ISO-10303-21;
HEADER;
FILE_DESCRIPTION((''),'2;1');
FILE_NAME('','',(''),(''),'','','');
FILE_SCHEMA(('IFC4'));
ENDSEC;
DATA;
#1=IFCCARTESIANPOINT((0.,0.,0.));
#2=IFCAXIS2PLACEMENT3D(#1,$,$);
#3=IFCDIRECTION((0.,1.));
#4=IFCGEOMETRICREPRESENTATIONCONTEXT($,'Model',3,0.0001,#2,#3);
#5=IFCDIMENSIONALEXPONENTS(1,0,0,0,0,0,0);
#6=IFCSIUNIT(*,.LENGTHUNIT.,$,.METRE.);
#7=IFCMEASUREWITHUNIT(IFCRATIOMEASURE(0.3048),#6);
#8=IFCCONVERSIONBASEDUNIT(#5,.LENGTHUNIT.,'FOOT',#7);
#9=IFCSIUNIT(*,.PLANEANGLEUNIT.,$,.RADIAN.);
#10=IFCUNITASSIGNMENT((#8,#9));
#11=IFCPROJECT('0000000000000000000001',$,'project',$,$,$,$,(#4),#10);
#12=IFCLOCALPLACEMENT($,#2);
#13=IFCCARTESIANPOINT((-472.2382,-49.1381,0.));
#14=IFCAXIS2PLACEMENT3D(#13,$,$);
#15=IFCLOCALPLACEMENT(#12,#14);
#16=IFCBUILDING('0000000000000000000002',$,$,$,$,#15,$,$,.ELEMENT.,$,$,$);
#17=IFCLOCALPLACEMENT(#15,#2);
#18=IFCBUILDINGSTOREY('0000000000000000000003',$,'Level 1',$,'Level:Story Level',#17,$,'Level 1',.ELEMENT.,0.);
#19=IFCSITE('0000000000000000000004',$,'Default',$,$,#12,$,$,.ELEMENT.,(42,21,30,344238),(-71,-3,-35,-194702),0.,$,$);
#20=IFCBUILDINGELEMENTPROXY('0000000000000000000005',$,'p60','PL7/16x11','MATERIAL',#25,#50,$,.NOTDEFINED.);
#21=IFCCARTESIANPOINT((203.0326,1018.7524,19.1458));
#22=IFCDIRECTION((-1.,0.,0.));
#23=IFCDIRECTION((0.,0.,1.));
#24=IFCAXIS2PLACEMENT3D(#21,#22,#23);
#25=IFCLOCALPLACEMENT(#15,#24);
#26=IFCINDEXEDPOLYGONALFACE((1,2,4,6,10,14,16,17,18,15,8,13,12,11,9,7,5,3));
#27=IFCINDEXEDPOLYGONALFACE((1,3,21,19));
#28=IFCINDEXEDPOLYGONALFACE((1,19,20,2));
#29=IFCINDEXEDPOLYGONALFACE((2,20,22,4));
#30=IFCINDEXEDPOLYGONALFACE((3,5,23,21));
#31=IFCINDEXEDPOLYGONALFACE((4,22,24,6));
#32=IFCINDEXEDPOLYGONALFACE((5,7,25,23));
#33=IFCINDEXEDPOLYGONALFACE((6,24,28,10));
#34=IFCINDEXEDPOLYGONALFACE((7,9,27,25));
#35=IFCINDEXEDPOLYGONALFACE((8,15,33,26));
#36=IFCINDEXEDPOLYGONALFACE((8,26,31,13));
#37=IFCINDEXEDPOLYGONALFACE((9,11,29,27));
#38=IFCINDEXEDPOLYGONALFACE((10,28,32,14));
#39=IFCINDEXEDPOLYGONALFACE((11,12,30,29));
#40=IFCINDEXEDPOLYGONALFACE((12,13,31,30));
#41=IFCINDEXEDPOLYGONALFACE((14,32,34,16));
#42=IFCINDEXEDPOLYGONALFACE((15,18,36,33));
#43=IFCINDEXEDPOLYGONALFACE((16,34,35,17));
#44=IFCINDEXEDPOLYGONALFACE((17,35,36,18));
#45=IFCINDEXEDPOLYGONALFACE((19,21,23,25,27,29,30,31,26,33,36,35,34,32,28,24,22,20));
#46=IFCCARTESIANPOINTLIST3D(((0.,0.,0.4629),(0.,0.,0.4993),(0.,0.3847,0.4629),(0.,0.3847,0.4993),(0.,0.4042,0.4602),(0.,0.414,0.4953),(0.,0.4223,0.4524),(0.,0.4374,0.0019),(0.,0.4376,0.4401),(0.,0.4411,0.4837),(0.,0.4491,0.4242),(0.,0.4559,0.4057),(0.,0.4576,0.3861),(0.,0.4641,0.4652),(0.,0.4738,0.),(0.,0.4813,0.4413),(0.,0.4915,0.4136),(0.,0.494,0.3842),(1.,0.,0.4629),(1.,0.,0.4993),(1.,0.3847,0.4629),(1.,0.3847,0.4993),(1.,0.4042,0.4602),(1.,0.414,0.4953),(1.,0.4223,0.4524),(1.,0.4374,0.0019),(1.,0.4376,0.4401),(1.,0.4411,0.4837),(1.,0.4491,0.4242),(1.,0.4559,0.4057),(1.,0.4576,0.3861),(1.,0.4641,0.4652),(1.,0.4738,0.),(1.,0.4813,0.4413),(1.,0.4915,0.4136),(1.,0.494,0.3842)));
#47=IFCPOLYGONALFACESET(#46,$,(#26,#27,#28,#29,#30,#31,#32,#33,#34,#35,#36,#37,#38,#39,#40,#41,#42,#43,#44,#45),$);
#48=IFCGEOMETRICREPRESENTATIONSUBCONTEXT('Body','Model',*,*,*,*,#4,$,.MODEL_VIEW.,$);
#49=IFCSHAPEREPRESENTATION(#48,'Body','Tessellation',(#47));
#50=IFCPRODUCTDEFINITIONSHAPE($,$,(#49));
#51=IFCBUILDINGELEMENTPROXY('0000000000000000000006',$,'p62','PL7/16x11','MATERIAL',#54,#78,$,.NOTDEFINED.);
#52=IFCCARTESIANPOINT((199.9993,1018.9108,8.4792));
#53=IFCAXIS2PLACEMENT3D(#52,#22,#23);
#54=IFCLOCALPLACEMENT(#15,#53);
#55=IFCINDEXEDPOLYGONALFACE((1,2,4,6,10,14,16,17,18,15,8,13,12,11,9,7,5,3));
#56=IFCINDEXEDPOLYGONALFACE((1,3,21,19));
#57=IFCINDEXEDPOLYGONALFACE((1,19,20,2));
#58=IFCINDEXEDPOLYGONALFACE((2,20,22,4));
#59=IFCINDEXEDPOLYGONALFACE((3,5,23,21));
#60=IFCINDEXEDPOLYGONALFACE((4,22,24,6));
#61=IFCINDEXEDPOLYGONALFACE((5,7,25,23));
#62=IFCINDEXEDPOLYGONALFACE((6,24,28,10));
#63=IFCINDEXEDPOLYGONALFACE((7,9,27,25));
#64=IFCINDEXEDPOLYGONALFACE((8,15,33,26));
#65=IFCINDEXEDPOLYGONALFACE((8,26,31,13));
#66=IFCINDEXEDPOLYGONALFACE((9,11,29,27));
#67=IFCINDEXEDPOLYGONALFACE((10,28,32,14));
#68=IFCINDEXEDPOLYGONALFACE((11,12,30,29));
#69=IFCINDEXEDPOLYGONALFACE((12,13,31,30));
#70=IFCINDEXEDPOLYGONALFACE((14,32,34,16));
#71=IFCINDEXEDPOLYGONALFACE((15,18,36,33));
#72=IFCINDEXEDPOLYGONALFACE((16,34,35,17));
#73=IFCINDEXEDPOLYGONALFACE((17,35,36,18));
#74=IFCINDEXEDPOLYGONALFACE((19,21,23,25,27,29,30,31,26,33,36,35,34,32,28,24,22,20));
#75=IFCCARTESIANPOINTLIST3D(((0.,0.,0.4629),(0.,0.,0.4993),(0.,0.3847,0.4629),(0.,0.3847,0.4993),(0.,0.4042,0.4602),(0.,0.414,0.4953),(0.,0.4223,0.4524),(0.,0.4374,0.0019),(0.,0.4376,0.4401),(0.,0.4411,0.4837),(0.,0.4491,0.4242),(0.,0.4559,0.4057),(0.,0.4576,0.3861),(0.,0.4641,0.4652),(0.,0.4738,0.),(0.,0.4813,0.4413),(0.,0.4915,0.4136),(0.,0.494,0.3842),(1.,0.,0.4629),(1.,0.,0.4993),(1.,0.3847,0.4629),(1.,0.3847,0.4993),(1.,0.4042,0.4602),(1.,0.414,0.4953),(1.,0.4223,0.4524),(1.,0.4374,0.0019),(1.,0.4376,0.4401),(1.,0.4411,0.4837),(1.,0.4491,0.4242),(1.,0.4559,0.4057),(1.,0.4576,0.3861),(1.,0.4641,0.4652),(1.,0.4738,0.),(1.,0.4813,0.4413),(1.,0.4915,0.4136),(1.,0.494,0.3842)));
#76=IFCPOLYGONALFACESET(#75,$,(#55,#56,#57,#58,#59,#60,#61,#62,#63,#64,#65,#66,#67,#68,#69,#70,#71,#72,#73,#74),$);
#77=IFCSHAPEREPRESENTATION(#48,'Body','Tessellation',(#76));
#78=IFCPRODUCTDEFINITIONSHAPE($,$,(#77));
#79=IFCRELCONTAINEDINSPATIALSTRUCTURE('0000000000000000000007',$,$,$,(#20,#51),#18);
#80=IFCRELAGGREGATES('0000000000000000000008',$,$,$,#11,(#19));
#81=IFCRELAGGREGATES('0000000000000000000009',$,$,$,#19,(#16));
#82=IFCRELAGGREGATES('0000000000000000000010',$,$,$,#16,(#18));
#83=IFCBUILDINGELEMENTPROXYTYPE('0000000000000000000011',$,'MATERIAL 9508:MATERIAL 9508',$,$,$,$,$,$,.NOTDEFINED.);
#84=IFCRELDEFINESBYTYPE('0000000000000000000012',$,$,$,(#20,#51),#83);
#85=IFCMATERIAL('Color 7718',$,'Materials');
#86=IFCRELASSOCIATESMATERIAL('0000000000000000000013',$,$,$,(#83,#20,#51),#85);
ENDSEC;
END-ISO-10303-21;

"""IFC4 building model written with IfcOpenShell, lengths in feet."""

from ifc_helpers import new_model, entity, si_unit, converted_unit, direction, frame, origin, place, context, subcontext, project, spatial, polyline, outline, extrude, source, transform, mapped, material, type_object, type_shapes, element, save


model = new_model("IFC4")

# Units and contexts
model_context = context("Model", 3, precision=0.0001, world=origin(), true_north=direction((0.0, 1.0)))
body_context = subcontext(model_context, "Body", "Model", "MODEL_VIEW")
ifc_project = project(units=[converted_unit("LENGTHUNIT", "FOOT", entity("IfcRatioMeasure", 0.3048), si_unit("LENGTHUNIT", "METRE"), dimensions=[1, 0, 0, 0, 0, 0, 0]), si_unit("PLANEANGLEUNIT", "RADIAN")], contexts=[model_context])

# Site, building, storey
site_placement = place(None, origin())
site = spatial("IfcSite", under=ifc_project, at=site_placement, Name="Default", CompositionType="ELEMENT", RefLatitude=(42, 21, 30, 344238), RefLongitude=(-71, -3, -35, -194702), RefElevation=0.0)
building_placement = place(site_placement, frame((-472.2382, -49.1381, 0.0)))
building = spatial("IfcBuilding", under=site, at=building_placement, CompositionType="ELEMENT")
storey_placement = place(building_placement, origin())
storey = spatial("IfcBuildingStorey", under=building, at=storey_placement, Name="Level 1", ObjectType="Level:Story Level", LongName="Level 1", CompositionType="ELEMENT", Elevation=0.0)

# Building element proxies
ifc_material_1 = material(Name="Color 7718", Category="Materials")
building_element_proxy_type_1 = type_object("IfcBuildingElementProxyType", Name="MATERIAL 9508:MATERIAL 9508", PredefinedType="NOTDEFINED", material=ifc_material_1)
shared_shape_1 = source(origin(), body_context, "Body", "SweptSolid", [
    extrude(outline(polyline([(0.0093, -0.1005), (0.3941, -0.1005), (0.3941, -0.0641), (0.0093, -0.0641), (-0.0101, -0.0614), (-0.0282, -0.0536), (-0.0436, -0.0413), (-0.055, -0.0254), (-0.0619, -0.0069), (-0.0635, 0.0127), (-0.0433, 0.3969), (-0.0798, 0.3988), (-0.0999, 0.0146), (-0.0974, -0.0148), (-0.0872, -0.0425), (-0.07, -0.0664), (-0.047, -0.0849), (-0.0199, -0.0965), (0.0093, -0.1005)])), frame((0.0, 0.3941, 0.3988), z_axis=(1.0, 0.0, 0.0), x_axis=(0.0, -1.0, 0.0)), (0.0, 0.0, 1.0), 1.0),
])
type_shapes(building_element_proxy_type_1, [shared_shape_1])
for number, where, z_axis, x_axis, name in (
    (1, (203.0326, 1018.7524, 19.1458), (-1.0, 0.0, 0.0), (0.0, 0.0, 1.0), "p60"),
    (2, (199.9993, 1018.9108, 8.4792), (-1.0, 0.0, 0.0), (0.0, 0.0, 1.0), "p62"),
):
    element("IfcBuildingElementProxy", number, at=place(building_placement, frame(where, z_axis=z_axis, x_axis=x_axis)), inside=storey, type_object=building_element_proxy_type_1, material=ifc_material_1, Name=name, Description="PL7/16x11", ObjectType="MATERIAL", PredefinedType="NOTDEFINED", context=body_context, shape_type="MappedRepresentation", body=[
        mapped(shared_shape_1, transform((0.0, 0.0, 0.0), scale=1.0)),
    ])

save(model, "model.ifc")
